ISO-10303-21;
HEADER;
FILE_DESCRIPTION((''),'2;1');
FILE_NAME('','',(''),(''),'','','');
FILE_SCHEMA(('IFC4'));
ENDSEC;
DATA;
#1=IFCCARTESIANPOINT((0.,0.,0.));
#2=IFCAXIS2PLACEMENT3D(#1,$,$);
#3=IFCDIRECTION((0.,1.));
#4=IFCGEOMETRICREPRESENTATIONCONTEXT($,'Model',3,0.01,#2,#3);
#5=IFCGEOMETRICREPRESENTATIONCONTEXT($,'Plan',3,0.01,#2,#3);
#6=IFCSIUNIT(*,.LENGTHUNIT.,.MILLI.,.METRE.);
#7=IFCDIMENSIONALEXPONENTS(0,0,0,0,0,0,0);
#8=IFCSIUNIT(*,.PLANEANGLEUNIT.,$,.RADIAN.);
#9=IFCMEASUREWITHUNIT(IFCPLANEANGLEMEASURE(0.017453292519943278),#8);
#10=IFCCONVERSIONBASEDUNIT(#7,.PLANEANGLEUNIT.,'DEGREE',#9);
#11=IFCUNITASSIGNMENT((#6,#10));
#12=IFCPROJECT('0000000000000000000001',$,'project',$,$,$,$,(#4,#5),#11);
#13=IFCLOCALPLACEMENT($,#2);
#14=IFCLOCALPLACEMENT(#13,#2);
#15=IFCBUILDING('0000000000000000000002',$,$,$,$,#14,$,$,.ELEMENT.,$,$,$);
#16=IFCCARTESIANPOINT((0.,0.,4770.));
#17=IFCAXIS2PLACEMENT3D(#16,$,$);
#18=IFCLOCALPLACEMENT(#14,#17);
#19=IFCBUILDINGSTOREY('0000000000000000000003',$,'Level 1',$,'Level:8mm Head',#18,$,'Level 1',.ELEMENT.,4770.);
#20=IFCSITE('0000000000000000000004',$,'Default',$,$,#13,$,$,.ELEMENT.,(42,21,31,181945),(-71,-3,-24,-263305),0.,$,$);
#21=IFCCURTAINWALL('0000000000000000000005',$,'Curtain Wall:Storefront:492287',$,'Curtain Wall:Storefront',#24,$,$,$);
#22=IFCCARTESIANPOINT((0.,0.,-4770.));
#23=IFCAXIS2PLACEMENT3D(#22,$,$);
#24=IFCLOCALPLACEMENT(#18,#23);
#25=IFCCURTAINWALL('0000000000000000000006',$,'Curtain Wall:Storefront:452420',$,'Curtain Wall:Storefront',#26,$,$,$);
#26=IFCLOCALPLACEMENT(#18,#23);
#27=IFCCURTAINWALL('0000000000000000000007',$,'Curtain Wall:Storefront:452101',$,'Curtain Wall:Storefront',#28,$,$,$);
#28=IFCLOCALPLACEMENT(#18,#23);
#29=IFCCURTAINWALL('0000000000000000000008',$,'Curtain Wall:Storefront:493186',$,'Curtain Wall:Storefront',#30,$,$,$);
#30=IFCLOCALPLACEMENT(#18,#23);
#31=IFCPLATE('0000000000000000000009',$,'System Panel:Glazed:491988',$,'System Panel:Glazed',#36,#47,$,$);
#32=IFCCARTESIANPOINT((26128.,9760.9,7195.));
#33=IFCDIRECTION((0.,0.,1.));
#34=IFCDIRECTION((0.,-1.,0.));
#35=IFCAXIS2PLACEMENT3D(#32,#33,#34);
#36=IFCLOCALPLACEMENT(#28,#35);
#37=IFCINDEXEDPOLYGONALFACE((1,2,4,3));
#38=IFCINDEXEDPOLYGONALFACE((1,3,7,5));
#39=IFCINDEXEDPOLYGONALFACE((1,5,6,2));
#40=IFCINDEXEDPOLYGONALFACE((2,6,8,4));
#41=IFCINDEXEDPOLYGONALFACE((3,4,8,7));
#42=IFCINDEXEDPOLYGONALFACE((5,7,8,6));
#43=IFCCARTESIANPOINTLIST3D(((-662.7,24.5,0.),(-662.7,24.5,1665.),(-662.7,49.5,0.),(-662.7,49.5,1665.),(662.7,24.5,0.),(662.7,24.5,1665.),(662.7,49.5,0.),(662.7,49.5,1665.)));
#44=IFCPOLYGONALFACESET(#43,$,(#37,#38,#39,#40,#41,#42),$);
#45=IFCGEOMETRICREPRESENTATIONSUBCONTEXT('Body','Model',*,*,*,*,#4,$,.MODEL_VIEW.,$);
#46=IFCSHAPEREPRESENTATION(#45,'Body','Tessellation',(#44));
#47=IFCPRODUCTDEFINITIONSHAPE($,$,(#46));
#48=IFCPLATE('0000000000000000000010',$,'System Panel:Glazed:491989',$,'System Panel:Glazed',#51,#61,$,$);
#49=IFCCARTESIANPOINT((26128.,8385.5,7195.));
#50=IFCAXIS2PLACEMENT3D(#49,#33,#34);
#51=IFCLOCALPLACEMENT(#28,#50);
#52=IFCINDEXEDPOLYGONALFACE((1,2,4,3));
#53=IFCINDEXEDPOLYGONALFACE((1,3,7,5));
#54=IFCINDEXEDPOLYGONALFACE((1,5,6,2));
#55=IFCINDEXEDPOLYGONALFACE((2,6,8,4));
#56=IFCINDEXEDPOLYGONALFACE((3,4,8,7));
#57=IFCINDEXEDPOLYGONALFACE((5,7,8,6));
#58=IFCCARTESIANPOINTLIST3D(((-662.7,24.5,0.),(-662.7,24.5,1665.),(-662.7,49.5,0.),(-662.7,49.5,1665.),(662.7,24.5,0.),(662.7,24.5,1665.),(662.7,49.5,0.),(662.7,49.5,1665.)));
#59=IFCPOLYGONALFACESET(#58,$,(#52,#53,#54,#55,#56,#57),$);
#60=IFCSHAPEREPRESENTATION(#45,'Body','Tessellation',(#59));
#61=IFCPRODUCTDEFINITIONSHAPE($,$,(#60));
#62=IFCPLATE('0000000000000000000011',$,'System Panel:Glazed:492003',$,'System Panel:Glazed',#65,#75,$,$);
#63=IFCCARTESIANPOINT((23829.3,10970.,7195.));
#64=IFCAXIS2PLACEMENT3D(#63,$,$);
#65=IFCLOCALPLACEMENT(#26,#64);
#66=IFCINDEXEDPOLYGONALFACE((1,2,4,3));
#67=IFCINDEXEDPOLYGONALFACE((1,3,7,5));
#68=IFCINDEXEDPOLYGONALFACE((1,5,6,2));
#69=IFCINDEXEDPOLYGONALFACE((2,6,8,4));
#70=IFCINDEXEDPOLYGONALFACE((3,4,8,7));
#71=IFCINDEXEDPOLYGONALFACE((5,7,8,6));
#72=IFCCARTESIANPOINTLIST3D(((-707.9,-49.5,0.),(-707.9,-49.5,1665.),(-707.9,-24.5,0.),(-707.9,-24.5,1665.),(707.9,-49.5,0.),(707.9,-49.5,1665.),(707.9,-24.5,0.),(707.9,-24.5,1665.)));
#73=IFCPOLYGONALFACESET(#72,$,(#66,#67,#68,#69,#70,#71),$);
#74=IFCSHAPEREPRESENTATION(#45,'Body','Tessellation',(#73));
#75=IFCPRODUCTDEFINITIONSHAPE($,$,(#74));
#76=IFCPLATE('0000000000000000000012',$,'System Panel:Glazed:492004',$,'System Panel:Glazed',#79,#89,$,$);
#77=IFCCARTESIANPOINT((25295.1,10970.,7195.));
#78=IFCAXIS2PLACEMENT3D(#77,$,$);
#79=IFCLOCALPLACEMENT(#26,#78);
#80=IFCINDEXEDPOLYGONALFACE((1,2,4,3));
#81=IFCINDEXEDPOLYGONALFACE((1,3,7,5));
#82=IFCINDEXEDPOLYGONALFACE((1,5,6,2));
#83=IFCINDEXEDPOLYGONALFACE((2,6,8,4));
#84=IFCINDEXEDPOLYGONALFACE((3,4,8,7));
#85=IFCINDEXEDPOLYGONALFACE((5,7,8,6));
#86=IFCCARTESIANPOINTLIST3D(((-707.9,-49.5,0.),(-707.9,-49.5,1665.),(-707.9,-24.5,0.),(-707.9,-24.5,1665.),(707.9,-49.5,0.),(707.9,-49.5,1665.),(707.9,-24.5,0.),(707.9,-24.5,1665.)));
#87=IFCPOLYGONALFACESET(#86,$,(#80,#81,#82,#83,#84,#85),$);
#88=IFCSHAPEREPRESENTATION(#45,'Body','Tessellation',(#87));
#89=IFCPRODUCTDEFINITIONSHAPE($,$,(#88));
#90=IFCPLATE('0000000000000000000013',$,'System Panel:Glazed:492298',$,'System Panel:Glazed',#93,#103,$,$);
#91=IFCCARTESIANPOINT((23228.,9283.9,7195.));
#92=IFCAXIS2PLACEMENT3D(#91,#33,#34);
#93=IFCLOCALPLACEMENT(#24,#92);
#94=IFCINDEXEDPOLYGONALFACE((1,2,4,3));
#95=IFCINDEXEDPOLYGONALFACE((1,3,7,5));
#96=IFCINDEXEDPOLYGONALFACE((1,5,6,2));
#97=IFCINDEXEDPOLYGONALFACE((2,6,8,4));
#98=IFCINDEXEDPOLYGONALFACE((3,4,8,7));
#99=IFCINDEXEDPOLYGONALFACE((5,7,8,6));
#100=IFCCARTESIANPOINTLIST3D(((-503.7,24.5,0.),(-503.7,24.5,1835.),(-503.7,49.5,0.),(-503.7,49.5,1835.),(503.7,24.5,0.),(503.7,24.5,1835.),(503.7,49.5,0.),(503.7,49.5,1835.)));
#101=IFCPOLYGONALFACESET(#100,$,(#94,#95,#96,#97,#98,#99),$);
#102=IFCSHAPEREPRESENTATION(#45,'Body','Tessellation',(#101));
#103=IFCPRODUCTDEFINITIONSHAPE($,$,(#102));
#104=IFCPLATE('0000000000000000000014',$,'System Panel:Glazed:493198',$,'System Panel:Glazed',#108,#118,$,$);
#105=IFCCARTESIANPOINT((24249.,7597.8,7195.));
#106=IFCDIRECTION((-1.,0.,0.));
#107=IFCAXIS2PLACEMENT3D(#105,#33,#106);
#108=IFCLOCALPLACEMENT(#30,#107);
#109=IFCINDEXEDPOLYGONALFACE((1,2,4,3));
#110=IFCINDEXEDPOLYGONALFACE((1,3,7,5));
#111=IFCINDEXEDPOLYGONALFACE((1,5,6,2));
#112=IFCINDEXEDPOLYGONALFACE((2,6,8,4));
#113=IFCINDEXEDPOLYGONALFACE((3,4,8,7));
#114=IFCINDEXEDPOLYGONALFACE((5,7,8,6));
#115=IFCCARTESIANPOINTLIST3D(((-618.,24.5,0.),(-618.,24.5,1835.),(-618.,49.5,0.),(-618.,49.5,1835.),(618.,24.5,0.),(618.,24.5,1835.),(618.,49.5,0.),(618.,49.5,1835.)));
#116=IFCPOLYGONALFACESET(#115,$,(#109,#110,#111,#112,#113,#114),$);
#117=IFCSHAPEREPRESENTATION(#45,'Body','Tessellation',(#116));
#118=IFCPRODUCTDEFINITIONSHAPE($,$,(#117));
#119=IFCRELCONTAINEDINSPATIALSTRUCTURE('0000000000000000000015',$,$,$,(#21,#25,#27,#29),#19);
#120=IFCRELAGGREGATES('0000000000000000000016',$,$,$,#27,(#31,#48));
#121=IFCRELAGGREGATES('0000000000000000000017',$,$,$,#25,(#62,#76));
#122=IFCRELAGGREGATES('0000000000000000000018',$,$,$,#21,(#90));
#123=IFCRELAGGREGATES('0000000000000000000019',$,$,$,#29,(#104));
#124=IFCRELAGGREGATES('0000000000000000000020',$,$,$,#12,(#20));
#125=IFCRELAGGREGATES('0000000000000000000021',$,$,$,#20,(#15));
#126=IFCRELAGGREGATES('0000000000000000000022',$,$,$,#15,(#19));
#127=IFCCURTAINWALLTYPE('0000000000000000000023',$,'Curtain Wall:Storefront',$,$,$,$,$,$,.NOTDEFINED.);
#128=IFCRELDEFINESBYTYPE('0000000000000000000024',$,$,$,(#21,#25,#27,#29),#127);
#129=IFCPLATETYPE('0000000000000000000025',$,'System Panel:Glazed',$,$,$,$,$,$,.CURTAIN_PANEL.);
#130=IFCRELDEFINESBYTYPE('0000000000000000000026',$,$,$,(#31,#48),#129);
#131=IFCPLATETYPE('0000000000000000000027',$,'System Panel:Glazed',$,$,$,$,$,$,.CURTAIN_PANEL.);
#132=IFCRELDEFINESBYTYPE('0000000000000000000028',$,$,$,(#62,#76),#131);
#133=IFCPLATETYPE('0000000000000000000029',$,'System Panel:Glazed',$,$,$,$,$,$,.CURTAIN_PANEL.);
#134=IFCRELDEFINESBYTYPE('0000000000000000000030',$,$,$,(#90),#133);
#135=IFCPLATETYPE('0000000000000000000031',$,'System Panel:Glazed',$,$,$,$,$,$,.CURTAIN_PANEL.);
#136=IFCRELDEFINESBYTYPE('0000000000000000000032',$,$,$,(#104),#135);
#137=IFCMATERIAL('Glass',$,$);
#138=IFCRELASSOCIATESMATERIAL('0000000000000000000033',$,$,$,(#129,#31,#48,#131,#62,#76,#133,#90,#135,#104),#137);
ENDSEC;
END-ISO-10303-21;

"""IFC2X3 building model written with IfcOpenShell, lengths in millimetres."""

from ifc_helpers import new_model, entity, si_unit, converted_unit, direction, frame, frame_2d, origin, origin_2d_with_axis, place, context, subcontext, project, spatial, rectangle, extrude, source, transform, mapped, material, type_object, type_shapes, element, aggregate, save


model = new_model("IFC2X3")

# Units and contexts
model_context = context("Model", 3, precision=0.01, world=origin(), true_north=direction((0.0, 1.0)))
plan_context = context("Plan", 3, precision=0.01, world=origin(), true_north=direction((0.0, 1.0)))
body_context = subcontext(model_context, "Body", "Model", "MODEL_VIEW")
ifc_project = project(units=[si_unit("LENGTHUNIT", "METRE", prefix="MILLI"), converted_unit("PLANEANGLEUNIT", "DEGREE", entity("IfcPlaneAngleMeasure", 0.017453292519943278), si_unit("PLANEANGLEUNIT", "RADIAN"), dimensions=[0, 0, 0, 0, 0, 0, 0])], contexts=[model_context, plan_context])

# Site, building, storey
site_placement = place(None, origin())
site = spatial("IfcSite", under=ifc_project, at=site_placement, Name="Default", CompositionType="ELEMENT", RefLatitude=(42, 21, 31, 181945), RefLongitude=(-71, -3, -24, -263305), RefElevation=0.0)
building_placement = place(site_placement, origin())
building = spatial("IfcBuilding", under=site, at=building_placement, CompositionType="ELEMENT")
storey_placement = place(building_placement, frame((0.0, 0.0, 4770.0)))
storey = spatial("IfcBuildingStorey", under=building, at=storey_placement, Name="Level 1", ObjectType="Level:8mm Head", LongName="Level 1", CompositionType="ELEMENT", Elevation=4770.0)

# Curtain walls
curtain_wall_type = type_object("IfcCurtainWallType", Name="Curtain Wall:Storefront", PredefinedType="NOTDEFINED")
curtain_wall_1_placement = place(storey_placement, frame((0.0, 0.0, -4770.0)))
curtain_wall_1 = element("IfcCurtainWall", 1, at=curtain_wall_1_placement, inside=storey, type_object=curtain_wall_type, Name="Curtain Wall:Storefront:492287", ObjectType="Curtain Wall:Storefront")
curtain_wall_2_placement = place(storey_placement, frame((0.0, 0.0, -4770.0)))
curtain_wall_2 = element("IfcCurtainWall", 2, at=curtain_wall_2_placement, inside=storey, type_object=curtain_wall_type, Name="Curtain Wall:Storefront:452420", ObjectType="Curtain Wall:Storefront")
curtain_wall_3_placement = place(storey_placement, frame((0.0, 0.0, -4770.0)))
curtain_wall_3 = element("IfcCurtainWall", 3, at=curtain_wall_3_placement, inside=storey, type_object=curtain_wall_type, Name="Curtain Wall:Storefront:452101", ObjectType="Curtain Wall:Storefront")

# Curtain wall
curtain_wall_4_placement = place(storey_placement, frame((0.0, 0.0, -4770.0)))
curtain_wall_4 = element("IfcCurtainWall", 4, at=curtain_wall_4_placement, inside=storey, type_object=curtain_wall_type, Name="Curtain Wall:Storefront:493186", ObjectType="Curtain Wall:Storefront")

# Plates
ifc_material_1 = material(Name="Glass")
plate_type_1 = type_object("IfcPlateType", Name="System Panel:Glazed", PredefinedType="CURTAIN_PANEL", material=ifc_material_1)
shared_shape_1 = source(origin(), body_context, "Body", "SweptSolid", [
    extrude(rectangle(XDim=25.0, YDim=1325.4, at=origin_2d_with_axis()), frame((0.0, 37.0, 0.0), z_axis=(0.0, 0.0, 1.0), x_axis=(0.0, 1.0, 0.0)), (0.0, 0.0, 1.0), 1665.0),
])
type_shapes(plate_type_1, [shared_shape_1])
plate_1_placement = place(curtain_wall_3_placement, frame((26128.0, 9760.9, 7195.0), z_axis=(0.0, 0.0, 1.0), x_axis=(0.0, -1.0, 0.0)))
plate_1 = element("IfcPlate", 5, at=plate_1_placement, type_object=plate_type_1, material=ifc_material_1, Name="System Panel:Glazed:491988", ObjectType="System Panel:Glazed", context=body_context, shape_type="MappedRepresentation", body=[
    mapped(shared_shape_1, transform((0.0, 0.0, 0.0), scale=1.0)),
])
plate_2_placement = place(curtain_wall_3_placement, frame((26128.0, 8385.5, 7195.0), z_axis=(0.0, 0.0, 1.0), x_axis=(0.0, -1.0, 0.0)))
plate_2 = element("IfcPlate", 6, at=plate_2_placement, type_object=plate_type_1, material=ifc_material_1, Name="System Panel:Glazed:491989", ObjectType="System Panel:Glazed", context=body_context, shape_type="MappedRepresentation", body=[
    mapped(shared_shape_1, transform((0.0, 0.0, 0.0), scale=1.0)),
])
aggregate(curtain_wall_3, [plate_1, plate_2])
plate_type_2 = type_object("IfcPlateType", Name="System Panel:Glazed", PredefinedType="CURTAIN_PANEL", material=ifc_material_1)
shared_shape_2 = source(origin(), body_context, "Body", "SweptSolid", [
    extrude(rectangle(XDim=25.0, YDim=1415.7, at=frame_2d((0.0, 0.0), x_axis=(1.0, 0.0))), frame((0.0, -37.0, 0.0), z_axis=(0.0, 0.0, 1.0), x_axis=(0.0, 1.0, 0.0)), (0.0, 0.0, 1.0), 1665.0),
])
type_shapes(plate_type_2, [shared_shape_2])
plate_3_placement = place(curtain_wall_2_placement, frame((23829.3, 10970.0, 7195.0)))
plate_3 = element("IfcPlate", 7, at=plate_3_placement, type_object=plate_type_2, material=ifc_material_1, Name="System Panel:Glazed:492003", ObjectType="System Panel:Glazed", context=body_context, shape_type="MappedRepresentation", body=[
    mapped(shared_shape_2, transform((0.0, 0.0, 0.0), scale=1.0)),
])
plate_4_placement = place(curtain_wall_2_placement, frame((25295.1, 10970.0, 7195.0)))
plate_4 = element("IfcPlate", 8, at=plate_4_placement, type_object=plate_type_2, material=ifc_material_1, Name="System Panel:Glazed:492004", ObjectType="System Panel:Glazed", context=body_context, shape_type="MappedRepresentation", body=[
    mapped(shared_shape_2, transform((0.0, 0.0, 0.0), scale=1.0)),
])
aggregate(curtain_wall_2, [plate_3, plate_4])
plate_type_3 = type_object("IfcPlateType", Name="System Panel:Glazed", PredefinedType="CURTAIN_PANEL", material=ifc_material_1)
shared_shape_3 = source(origin(), body_context, "Body", "SweptSolid", [
    extrude(rectangle(XDim=25.0, YDim=1007.4, at=origin_2d_with_axis()), frame((0.0, 37.0, 0.0), z_axis=(0.0, 0.0, 1.0), x_axis=(0.0, 1.0, 0.0)), (0.0, 0.0, 1.0), 1835.0),
])
type_shapes(plate_type_3, [shared_shape_3])
plate_5_placement = place(curtain_wall_1_placement, frame((23228.0, 9283.9, 7195.0), z_axis=(0.0, 0.0, 1.0), x_axis=(0.0, -1.0, 0.0)))
plate_5 = element("IfcPlate", 9, at=plate_5_placement, type_object=plate_type_3, material=ifc_material_1, Name="System Panel:Glazed:492298", ObjectType="System Panel:Glazed", context=body_context, shape_type="MappedRepresentation", body=[
    mapped(shared_shape_3, transform((0.0, 0.0, 0.0), scale=1.0)),
])
aggregate(curtain_wall_1, [plate_5])
plate_type_4 = type_object("IfcPlateType", Name="System Panel:Glazed", PredefinedType="CURTAIN_PANEL", material=ifc_material_1)
shared_shape_4 = source(origin(), body_context, "Body", "SweptSolid", [
    extrude(rectangle(XDim=25.0, YDim=1236.0, at=origin_2d_with_axis()), frame((0.0, 37.0, 0.0), z_axis=(0.0, 0.0, 1.0), x_axis=(0.0, 1.0, 0.0)), (0.0, 0.0, 1.0), 1835.0),
])
type_shapes(plate_type_4, [shared_shape_4])
plate_6_placement = place(curtain_wall_4_placement, frame((24249.0, 7597.8, 7195.0), z_axis=(0.0, 0.0, 1.0), x_axis=(-1.0, 0.0, 0.0)))
plate_6 = element("IfcPlate", 10, at=plate_6_placement, type_object=plate_type_4, material=ifc_material_1, Name="System Panel:Glazed:493198", ObjectType="System Panel:Glazed", context=body_context, shape_type="MappedRepresentation", body=[
    mapped(shared_shape_4, transform((0.0, 0.0, 0.0), scale=1.0)),
])
aggregate(curtain_wall_4, [plate_6])

save(model, "model.ifc")
